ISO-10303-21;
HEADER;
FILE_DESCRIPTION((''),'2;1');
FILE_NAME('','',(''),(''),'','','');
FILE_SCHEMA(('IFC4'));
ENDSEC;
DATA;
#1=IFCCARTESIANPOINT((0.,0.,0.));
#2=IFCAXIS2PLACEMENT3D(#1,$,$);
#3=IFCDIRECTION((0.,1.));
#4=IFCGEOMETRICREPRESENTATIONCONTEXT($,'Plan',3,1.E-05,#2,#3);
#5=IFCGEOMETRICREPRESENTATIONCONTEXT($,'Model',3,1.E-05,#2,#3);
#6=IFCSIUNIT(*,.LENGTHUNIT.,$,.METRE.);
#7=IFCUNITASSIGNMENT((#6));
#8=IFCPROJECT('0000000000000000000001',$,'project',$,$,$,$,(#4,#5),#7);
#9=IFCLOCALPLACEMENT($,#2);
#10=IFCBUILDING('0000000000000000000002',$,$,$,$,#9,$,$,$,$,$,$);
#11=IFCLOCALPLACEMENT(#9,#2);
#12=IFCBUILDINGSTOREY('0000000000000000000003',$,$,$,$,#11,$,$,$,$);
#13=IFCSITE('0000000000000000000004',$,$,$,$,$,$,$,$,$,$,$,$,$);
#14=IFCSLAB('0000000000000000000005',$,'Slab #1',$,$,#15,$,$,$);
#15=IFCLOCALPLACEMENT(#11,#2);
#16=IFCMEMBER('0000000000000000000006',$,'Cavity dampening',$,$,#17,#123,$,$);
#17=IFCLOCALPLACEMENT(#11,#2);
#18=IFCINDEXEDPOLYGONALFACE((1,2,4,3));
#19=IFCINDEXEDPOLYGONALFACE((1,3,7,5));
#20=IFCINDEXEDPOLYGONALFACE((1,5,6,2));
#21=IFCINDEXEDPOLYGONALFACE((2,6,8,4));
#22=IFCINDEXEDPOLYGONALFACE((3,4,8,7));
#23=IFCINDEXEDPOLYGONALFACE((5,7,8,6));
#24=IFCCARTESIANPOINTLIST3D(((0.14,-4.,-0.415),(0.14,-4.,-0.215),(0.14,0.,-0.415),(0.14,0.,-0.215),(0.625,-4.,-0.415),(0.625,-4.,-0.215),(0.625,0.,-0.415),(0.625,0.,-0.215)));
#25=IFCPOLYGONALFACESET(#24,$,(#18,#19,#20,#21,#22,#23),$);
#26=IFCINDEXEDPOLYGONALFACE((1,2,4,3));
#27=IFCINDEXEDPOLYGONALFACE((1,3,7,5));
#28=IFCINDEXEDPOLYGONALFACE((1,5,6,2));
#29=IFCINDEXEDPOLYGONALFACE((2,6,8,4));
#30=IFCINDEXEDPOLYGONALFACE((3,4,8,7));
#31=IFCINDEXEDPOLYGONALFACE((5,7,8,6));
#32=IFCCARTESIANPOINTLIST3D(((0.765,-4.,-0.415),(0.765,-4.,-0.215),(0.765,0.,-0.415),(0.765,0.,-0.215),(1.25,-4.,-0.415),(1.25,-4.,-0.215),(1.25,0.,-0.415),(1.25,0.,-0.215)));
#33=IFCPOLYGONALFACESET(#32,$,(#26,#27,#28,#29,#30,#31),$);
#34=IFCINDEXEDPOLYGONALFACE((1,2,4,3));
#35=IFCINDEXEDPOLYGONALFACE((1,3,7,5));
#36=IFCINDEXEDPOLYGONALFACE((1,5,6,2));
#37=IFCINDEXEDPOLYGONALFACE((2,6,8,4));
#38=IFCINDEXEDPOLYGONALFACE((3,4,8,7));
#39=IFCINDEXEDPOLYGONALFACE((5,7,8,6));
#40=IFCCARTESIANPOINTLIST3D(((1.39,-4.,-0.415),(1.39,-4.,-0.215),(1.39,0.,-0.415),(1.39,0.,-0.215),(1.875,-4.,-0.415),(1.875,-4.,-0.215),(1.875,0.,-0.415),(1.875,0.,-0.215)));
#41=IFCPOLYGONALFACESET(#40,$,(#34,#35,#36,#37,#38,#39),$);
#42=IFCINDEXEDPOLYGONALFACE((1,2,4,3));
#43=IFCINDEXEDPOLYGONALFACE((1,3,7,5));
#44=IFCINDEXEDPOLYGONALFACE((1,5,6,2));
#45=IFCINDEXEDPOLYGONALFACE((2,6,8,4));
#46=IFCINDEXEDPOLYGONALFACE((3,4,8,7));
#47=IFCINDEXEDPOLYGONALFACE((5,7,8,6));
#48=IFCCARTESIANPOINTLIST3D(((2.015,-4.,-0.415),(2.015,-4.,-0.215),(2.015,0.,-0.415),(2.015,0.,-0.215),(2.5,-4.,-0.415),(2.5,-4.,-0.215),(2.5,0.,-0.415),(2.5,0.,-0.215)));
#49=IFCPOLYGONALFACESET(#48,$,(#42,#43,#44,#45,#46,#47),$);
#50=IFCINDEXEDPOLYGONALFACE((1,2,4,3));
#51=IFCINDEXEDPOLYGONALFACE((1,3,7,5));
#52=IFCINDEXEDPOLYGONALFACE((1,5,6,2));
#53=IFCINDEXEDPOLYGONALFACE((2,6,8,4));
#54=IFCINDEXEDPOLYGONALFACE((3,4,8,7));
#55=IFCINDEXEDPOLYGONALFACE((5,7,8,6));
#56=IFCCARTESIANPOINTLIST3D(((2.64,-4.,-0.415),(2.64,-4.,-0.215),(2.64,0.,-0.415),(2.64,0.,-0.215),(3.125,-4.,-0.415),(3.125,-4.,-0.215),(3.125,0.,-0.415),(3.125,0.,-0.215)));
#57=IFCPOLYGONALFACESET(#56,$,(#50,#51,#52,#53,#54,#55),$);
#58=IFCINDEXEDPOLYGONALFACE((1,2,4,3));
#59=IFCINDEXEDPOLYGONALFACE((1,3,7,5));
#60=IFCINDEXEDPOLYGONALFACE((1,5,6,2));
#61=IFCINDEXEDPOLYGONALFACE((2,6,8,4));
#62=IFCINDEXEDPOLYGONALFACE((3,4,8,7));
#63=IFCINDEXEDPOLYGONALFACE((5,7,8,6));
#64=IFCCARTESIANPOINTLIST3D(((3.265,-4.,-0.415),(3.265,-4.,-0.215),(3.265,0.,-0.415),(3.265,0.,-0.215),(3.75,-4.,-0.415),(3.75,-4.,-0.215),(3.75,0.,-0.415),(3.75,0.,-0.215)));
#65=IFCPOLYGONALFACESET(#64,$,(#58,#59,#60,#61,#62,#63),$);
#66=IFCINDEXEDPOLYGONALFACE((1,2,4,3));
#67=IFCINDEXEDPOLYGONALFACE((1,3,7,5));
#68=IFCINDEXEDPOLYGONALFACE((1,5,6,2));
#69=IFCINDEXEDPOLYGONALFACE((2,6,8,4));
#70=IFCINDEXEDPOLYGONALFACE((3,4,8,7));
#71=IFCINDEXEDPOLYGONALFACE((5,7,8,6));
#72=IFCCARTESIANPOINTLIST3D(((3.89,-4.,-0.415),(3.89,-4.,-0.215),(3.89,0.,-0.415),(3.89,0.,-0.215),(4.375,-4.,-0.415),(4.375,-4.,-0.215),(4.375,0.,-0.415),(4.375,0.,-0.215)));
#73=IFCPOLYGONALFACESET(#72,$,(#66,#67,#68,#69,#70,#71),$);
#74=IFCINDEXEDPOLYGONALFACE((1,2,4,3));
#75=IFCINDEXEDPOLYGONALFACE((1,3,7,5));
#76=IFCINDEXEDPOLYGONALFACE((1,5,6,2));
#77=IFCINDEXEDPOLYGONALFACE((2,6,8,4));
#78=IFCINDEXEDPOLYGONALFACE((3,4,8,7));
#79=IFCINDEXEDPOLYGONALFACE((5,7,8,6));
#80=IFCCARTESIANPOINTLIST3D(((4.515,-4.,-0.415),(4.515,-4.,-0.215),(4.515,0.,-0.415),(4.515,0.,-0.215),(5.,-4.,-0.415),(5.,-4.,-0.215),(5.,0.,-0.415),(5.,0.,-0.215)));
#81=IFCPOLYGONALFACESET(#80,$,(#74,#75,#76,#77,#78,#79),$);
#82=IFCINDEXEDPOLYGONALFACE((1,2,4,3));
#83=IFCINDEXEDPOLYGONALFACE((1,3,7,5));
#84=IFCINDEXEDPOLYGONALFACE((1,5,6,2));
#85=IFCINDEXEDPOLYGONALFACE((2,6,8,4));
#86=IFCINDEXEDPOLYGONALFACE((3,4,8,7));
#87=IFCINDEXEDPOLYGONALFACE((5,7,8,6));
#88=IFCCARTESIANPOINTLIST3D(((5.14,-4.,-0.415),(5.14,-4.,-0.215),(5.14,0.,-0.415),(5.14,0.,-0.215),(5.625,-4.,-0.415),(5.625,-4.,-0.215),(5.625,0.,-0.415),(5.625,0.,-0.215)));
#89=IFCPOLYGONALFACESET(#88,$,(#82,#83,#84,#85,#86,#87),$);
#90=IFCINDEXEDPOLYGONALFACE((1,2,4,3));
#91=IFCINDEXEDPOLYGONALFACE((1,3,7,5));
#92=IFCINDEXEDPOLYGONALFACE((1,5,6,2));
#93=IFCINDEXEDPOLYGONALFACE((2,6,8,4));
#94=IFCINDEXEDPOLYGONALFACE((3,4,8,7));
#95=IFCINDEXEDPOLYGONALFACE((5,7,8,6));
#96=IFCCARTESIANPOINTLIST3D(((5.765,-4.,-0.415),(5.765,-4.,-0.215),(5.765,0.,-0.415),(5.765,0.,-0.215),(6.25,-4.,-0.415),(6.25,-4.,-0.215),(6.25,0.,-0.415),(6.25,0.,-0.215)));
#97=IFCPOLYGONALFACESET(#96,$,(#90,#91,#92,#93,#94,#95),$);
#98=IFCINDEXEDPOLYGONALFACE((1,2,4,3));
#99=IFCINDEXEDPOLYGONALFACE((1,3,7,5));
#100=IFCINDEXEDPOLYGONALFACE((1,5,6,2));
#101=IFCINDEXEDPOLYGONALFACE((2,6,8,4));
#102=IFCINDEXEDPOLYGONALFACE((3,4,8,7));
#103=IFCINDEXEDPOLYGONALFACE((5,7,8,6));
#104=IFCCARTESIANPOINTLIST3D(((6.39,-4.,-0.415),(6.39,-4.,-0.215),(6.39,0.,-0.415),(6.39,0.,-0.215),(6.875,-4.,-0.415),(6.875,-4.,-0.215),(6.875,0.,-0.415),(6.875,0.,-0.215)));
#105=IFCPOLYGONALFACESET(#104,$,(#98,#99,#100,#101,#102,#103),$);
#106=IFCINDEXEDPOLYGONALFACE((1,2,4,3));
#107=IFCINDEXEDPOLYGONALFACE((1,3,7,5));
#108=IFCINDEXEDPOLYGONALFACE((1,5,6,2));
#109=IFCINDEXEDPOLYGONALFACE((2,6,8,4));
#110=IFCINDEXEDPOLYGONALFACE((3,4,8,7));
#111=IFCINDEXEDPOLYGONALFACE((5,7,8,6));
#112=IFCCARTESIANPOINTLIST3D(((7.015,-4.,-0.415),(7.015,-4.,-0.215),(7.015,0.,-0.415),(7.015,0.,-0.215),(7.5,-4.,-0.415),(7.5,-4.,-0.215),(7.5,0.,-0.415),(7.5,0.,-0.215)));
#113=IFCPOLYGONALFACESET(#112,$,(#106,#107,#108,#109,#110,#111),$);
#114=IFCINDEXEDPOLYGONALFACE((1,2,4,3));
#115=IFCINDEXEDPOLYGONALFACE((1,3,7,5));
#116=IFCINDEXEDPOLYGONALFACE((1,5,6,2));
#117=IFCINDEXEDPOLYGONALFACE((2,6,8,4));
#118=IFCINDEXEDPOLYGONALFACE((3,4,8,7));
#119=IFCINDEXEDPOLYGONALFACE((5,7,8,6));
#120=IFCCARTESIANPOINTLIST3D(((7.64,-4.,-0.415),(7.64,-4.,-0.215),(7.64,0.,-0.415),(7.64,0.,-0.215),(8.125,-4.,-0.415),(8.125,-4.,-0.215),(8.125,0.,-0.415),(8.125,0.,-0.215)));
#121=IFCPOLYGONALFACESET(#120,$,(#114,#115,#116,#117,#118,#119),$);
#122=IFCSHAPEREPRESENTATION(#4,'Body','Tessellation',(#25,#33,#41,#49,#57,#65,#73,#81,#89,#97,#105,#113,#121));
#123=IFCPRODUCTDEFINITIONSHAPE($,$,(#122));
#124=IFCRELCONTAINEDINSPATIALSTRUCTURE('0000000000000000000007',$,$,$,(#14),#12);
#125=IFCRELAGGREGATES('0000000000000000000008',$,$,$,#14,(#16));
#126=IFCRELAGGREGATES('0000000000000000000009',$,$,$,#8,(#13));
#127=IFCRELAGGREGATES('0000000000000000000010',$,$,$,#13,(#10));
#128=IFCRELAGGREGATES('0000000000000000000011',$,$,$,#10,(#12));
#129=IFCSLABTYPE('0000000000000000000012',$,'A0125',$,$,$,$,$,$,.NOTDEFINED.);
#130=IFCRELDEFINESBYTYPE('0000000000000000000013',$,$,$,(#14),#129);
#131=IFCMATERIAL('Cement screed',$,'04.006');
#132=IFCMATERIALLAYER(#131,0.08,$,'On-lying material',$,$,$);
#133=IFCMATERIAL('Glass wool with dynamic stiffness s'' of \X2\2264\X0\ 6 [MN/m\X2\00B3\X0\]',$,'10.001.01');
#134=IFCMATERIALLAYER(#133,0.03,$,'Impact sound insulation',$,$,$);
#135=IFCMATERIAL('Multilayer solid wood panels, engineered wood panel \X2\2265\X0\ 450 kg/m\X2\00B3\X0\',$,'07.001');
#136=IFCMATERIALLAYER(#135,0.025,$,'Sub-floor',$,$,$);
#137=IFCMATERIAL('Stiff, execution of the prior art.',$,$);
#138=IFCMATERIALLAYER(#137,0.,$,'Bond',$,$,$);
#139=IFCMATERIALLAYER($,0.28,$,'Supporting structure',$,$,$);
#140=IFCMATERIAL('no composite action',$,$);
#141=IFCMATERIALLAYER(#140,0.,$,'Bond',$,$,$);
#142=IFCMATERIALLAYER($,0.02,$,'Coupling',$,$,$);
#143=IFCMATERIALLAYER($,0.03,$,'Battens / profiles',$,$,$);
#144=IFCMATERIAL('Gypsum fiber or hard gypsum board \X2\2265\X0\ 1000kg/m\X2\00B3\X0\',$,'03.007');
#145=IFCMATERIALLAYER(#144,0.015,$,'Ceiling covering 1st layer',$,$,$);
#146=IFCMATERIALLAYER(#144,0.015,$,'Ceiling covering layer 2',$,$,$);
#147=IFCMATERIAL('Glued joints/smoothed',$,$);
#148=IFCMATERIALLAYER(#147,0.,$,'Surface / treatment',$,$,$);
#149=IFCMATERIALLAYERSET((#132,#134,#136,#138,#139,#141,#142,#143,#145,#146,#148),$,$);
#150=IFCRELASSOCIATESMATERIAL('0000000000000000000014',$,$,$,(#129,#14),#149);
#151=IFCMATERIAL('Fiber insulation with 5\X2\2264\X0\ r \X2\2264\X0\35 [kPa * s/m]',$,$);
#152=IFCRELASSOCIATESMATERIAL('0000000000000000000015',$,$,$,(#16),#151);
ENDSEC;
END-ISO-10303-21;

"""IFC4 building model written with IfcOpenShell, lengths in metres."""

from ifc_helpers import new_model, si_unit, direction, frame, frame_2d, origin, place, context, project, spatial, rectangle, extrude, material, layer, layer_set, type_object, element, aggregate, save


model = new_model("IFC4")

# Units and contexts
plan_context = context("Plan", 3, precision=1e-05, world=origin(), true_north=direction((0.0, 1.0)))
model_context = context("Model", 3, precision=1e-05, world=origin(), true_north=direction((0.0, 1.0)))
ifc_project = project(units=[si_unit("LENGTHUNIT", "METRE")], contexts=[plan_context, model_context])

# Site, building, storey
site = spatial("IfcSite", under=ifc_project)
building_placement = place(None, origin())
building = spatial("IfcBuilding", under=site, at=building_placement)
storey_placement = place(building_placement, origin())
storey = spatial("IfcBuildingStorey", under=building, at=storey_placement)

# Slab, member
ifc_material_1 = material(Name="Cement screed", Category="04.006")
ifc_layer_1 = layer(ifc_material_1, 0.08, Name="On-lying material")
ifc_material_2 = material(Name="Glass wool with dynamic stiffness s' of ≤ 6 [MN/m³]", Category="10.001.01")
ifc_layer_2 = layer(ifc_material_2, 0.03, Name="Impact sound insulation")
ifc_material_3 = material(Name="Multilayer solid wood panels, engineered wood panel ≥ 450 kg/m³", Category="07.001")
ifc_layer_3 = layer(ifc_material_3, 0.025, Name="Sub-floor")
ifc_material_4 = material(Name="Stiff, execution of the prior art.")
ifc_layer_4 = layer(ifc_material_4, 0.0, Name="Bond")
ifc_layer_5 = layer(None, 0.28, Name="Supporting structure")
ifc_material_5 = material(Name="no composite action")
ifc_layer_6 = layer(ifc_material_5, 0.0, Name="Bond")
ifc_layer_7 = layer(None, 0.02, Name="Coupling")
ifc_layer_8 = layer(None, 0.03, Name="Battens / profiles")
ifc_material_6 = material(Name="Gypsum fiber or hard gypsum board ≥ 1000kg/m³", Category="03.007")
ifc_layer_9 = layer(ifc_material_6, 0.015, Name="Ceiling covering 1st layer")
ifc_layer_10 = layer(ifc_material_6, 0.015, Name="Ceiling covering layer 2")
ifc_material_7 = material(Name="Glued joints/smoothed")
ifc_layer_11 = layer(ifc_material_7, 0.0, Name="Surface / treatment")
ifc_layer_set = layer_set([ifc_layer_1, ifc_layer_2, ifc_layer_3, ifc_layer_4, ifc_layer_5, ifc_layer_6, ifc_layer_7, ifc_layer_8, ifc_layer_9, ifc_layer_10, ifc_layer_11])
slab_type = type_object("IfcSlabType", Name="A0125", PredefinedType="NOTDEFINED", material=ifc_layer_set)
slab_placement = place(None, frame((0.0, 0.0, 0.0), z_axis=(0.0, 0.0, -1.0), x_axis=(1.0, 0.0, 0.0)))
slab = element("IfcSlab", 1, at=slab_placement, inside=storey, type_object=slab_type, material=ifc_layer_set, Name="Slab #1")
ifc_material_8 = material(Name="Fiber insulation with 5≤ r ≤35 [kPa * s/m]")
member_1_placement = place(slab_placement, origin())
member_1 = element("IfcMember", 2, at=member_1_placement, material=ifc_material_8, Name="Cavity dampening", context=plan_context, shape_type="SweptSolid", body=[
    extrude(rectangle(XDim=0.485, YDim=0.2, at=frame_2d((0.2425, 0.1), x_axis=(1.0, 0.0))), frame((0.14, 4.0, 0.215), z_axis=(0.0, -1.0, 0.0), x_axis=(1.0, 0.0, 0.0)), (0.0, 0.0, 1.0), 4.0),
    extrude(rectangle(XDim=0.485, YDim=0.2, at=frame_2d((0.2425, 0.1), x_axis=(1.0, 0.0))), frame((0.765, 4.0, 0.215), z_axis=(0.0, -1.0, 0.0), x_axis=(1.0, 0.0, 0.0)), (0.0, 0.0, 1.0), 4.0),
    extrude(rectangle(XDim=0.485, YDim=0.2, at=frame_2d((0.2425, 0.1), x_axis=(1.0, 0.0))), frame((1.39, 4.0, 0.215), z_axis=(0.0, -1.0, 0.0), x_axis=(1.0, 0.0, 0.0)), (0.0, 0.0, 1.0), 4.0),
    extrude(rectangle(XDim=0.485, YDim=0.2, at=frame_2d((0.2425, 0.1), x_axis=(1.0, 0.0))), frame((2.015, 4.0, 0.215), z_axis=(0.0, -1.0, 0.0), x_axis=(1.0, 0.0, 0.0)), (0.0, 0.0, 1.0), 4.0),
    extrude(rectangle(XDim=0.485, YDim=0.2, at=frame_2d((0.2425, 0.1), x_axis=(1.0, 0.0))), frame((2.64, 4.0, 0.215), z_axis=(0.0, -1.0, 0.0), x_axis=(1.0, 0.0, 0.0)), (0.0, 0.0, 1.0), 4.0),
    extrude(rectangle(XDim=0.485, YDim=0.2, at=frame_2d((0.2425, 0.1), x_axis=(1.0, 0.0))), frame((3.265, 4.0, 0.215), z_axis=(0.0, -1.0, 0.0), x_axis=(1.0, 0.0, 0.0)), (0.0, 0.0, 1.0), 4.0),
    extrude(rectangle(XDim=0.485, YDim=0.2, at=frame_2d((0.2425, 0.1), x_axis=(1.0, 0.0))), frame((3.89, 4.0, 0.215), z_axis=(0.0, -1.0, 0.0), x_axis=(1.0, 0.0, 0.0)), (0.0, 0.0, 1.0), 4.0),
    extrude(rectangle(XDim=0.485, YDim=0.2, at=frame_2d((0.2425, 0.1), x_axis=(1.0, 0.0))), frame((4.515, 4.0, 0.215), z_axis=(0.0, -1.0, 0.0), x_axis=(1.0, 0.0, 0.0)), (0.0, 0.0, 1.0), 4.0),
    extrude(rectangle(XDim=0.485, YDim=0.2, at=frame_2d((0.2425, 0.1), x_axis=(1.0, 0.0))), frame((5.14, 4.0, 0.215), z_axis=(0.0, -1.0, 0.0), x_axis=(1.0, 0.0, 0.0)), (0.0, 0.0, 1.0), 4.0),
    extrude(rectangle(XDim=0.485, YDim=0.2, at=frame_2d((0.2425, 0.1), x_axis=(1.0, 0.0))), frame((5.765, 4.0, 0.215), z_axis=(0.0, -1.0, 0.0), x_axis=(1.0, 0.0, 0.0)), (0.0, 0.0, 1.0), 4.0),
    extrude(rectangle(XDim=0.485, YDim=0.2, at=frame_2d((0.2425, 0.1), x_axis=(1.0, 0.0))), frame((6.39, 4.0, 0.215), z_axis=(0.0, -1.0, 0.0), x_axis=(1.0, 0.0, 0.0)), (0.0, 0.0, 1.0), 4.0),
    extrude(rectangle(XDim=0.485, YDim=0.2, at=frame_2d((0.2425, 0.1), x_axis=(1.0, 0.0))), frame((7.015, 4.0, 0.215), z_axis=(0.0, -1.0, 0.0), x_axis=(1.0, 0.0, 0.0)), (0.0, 0.0, 1.0), 4.0),
    extrude(rectangle(XDim=0.485, YDim=0.2, at=frame_2d((0.2425, 0.1), x_axis=(1.0, 0.0))), frame((7.64, 4.0, 0.215), z_axis=(0.0, -1.0, 0.0), x_axis=(1.0, 0.0, 0.0)), (0.0, 0.0, 1.0), 4.0),
])
aggregate(slab, [member_1])

save(model, "model.ifc")
